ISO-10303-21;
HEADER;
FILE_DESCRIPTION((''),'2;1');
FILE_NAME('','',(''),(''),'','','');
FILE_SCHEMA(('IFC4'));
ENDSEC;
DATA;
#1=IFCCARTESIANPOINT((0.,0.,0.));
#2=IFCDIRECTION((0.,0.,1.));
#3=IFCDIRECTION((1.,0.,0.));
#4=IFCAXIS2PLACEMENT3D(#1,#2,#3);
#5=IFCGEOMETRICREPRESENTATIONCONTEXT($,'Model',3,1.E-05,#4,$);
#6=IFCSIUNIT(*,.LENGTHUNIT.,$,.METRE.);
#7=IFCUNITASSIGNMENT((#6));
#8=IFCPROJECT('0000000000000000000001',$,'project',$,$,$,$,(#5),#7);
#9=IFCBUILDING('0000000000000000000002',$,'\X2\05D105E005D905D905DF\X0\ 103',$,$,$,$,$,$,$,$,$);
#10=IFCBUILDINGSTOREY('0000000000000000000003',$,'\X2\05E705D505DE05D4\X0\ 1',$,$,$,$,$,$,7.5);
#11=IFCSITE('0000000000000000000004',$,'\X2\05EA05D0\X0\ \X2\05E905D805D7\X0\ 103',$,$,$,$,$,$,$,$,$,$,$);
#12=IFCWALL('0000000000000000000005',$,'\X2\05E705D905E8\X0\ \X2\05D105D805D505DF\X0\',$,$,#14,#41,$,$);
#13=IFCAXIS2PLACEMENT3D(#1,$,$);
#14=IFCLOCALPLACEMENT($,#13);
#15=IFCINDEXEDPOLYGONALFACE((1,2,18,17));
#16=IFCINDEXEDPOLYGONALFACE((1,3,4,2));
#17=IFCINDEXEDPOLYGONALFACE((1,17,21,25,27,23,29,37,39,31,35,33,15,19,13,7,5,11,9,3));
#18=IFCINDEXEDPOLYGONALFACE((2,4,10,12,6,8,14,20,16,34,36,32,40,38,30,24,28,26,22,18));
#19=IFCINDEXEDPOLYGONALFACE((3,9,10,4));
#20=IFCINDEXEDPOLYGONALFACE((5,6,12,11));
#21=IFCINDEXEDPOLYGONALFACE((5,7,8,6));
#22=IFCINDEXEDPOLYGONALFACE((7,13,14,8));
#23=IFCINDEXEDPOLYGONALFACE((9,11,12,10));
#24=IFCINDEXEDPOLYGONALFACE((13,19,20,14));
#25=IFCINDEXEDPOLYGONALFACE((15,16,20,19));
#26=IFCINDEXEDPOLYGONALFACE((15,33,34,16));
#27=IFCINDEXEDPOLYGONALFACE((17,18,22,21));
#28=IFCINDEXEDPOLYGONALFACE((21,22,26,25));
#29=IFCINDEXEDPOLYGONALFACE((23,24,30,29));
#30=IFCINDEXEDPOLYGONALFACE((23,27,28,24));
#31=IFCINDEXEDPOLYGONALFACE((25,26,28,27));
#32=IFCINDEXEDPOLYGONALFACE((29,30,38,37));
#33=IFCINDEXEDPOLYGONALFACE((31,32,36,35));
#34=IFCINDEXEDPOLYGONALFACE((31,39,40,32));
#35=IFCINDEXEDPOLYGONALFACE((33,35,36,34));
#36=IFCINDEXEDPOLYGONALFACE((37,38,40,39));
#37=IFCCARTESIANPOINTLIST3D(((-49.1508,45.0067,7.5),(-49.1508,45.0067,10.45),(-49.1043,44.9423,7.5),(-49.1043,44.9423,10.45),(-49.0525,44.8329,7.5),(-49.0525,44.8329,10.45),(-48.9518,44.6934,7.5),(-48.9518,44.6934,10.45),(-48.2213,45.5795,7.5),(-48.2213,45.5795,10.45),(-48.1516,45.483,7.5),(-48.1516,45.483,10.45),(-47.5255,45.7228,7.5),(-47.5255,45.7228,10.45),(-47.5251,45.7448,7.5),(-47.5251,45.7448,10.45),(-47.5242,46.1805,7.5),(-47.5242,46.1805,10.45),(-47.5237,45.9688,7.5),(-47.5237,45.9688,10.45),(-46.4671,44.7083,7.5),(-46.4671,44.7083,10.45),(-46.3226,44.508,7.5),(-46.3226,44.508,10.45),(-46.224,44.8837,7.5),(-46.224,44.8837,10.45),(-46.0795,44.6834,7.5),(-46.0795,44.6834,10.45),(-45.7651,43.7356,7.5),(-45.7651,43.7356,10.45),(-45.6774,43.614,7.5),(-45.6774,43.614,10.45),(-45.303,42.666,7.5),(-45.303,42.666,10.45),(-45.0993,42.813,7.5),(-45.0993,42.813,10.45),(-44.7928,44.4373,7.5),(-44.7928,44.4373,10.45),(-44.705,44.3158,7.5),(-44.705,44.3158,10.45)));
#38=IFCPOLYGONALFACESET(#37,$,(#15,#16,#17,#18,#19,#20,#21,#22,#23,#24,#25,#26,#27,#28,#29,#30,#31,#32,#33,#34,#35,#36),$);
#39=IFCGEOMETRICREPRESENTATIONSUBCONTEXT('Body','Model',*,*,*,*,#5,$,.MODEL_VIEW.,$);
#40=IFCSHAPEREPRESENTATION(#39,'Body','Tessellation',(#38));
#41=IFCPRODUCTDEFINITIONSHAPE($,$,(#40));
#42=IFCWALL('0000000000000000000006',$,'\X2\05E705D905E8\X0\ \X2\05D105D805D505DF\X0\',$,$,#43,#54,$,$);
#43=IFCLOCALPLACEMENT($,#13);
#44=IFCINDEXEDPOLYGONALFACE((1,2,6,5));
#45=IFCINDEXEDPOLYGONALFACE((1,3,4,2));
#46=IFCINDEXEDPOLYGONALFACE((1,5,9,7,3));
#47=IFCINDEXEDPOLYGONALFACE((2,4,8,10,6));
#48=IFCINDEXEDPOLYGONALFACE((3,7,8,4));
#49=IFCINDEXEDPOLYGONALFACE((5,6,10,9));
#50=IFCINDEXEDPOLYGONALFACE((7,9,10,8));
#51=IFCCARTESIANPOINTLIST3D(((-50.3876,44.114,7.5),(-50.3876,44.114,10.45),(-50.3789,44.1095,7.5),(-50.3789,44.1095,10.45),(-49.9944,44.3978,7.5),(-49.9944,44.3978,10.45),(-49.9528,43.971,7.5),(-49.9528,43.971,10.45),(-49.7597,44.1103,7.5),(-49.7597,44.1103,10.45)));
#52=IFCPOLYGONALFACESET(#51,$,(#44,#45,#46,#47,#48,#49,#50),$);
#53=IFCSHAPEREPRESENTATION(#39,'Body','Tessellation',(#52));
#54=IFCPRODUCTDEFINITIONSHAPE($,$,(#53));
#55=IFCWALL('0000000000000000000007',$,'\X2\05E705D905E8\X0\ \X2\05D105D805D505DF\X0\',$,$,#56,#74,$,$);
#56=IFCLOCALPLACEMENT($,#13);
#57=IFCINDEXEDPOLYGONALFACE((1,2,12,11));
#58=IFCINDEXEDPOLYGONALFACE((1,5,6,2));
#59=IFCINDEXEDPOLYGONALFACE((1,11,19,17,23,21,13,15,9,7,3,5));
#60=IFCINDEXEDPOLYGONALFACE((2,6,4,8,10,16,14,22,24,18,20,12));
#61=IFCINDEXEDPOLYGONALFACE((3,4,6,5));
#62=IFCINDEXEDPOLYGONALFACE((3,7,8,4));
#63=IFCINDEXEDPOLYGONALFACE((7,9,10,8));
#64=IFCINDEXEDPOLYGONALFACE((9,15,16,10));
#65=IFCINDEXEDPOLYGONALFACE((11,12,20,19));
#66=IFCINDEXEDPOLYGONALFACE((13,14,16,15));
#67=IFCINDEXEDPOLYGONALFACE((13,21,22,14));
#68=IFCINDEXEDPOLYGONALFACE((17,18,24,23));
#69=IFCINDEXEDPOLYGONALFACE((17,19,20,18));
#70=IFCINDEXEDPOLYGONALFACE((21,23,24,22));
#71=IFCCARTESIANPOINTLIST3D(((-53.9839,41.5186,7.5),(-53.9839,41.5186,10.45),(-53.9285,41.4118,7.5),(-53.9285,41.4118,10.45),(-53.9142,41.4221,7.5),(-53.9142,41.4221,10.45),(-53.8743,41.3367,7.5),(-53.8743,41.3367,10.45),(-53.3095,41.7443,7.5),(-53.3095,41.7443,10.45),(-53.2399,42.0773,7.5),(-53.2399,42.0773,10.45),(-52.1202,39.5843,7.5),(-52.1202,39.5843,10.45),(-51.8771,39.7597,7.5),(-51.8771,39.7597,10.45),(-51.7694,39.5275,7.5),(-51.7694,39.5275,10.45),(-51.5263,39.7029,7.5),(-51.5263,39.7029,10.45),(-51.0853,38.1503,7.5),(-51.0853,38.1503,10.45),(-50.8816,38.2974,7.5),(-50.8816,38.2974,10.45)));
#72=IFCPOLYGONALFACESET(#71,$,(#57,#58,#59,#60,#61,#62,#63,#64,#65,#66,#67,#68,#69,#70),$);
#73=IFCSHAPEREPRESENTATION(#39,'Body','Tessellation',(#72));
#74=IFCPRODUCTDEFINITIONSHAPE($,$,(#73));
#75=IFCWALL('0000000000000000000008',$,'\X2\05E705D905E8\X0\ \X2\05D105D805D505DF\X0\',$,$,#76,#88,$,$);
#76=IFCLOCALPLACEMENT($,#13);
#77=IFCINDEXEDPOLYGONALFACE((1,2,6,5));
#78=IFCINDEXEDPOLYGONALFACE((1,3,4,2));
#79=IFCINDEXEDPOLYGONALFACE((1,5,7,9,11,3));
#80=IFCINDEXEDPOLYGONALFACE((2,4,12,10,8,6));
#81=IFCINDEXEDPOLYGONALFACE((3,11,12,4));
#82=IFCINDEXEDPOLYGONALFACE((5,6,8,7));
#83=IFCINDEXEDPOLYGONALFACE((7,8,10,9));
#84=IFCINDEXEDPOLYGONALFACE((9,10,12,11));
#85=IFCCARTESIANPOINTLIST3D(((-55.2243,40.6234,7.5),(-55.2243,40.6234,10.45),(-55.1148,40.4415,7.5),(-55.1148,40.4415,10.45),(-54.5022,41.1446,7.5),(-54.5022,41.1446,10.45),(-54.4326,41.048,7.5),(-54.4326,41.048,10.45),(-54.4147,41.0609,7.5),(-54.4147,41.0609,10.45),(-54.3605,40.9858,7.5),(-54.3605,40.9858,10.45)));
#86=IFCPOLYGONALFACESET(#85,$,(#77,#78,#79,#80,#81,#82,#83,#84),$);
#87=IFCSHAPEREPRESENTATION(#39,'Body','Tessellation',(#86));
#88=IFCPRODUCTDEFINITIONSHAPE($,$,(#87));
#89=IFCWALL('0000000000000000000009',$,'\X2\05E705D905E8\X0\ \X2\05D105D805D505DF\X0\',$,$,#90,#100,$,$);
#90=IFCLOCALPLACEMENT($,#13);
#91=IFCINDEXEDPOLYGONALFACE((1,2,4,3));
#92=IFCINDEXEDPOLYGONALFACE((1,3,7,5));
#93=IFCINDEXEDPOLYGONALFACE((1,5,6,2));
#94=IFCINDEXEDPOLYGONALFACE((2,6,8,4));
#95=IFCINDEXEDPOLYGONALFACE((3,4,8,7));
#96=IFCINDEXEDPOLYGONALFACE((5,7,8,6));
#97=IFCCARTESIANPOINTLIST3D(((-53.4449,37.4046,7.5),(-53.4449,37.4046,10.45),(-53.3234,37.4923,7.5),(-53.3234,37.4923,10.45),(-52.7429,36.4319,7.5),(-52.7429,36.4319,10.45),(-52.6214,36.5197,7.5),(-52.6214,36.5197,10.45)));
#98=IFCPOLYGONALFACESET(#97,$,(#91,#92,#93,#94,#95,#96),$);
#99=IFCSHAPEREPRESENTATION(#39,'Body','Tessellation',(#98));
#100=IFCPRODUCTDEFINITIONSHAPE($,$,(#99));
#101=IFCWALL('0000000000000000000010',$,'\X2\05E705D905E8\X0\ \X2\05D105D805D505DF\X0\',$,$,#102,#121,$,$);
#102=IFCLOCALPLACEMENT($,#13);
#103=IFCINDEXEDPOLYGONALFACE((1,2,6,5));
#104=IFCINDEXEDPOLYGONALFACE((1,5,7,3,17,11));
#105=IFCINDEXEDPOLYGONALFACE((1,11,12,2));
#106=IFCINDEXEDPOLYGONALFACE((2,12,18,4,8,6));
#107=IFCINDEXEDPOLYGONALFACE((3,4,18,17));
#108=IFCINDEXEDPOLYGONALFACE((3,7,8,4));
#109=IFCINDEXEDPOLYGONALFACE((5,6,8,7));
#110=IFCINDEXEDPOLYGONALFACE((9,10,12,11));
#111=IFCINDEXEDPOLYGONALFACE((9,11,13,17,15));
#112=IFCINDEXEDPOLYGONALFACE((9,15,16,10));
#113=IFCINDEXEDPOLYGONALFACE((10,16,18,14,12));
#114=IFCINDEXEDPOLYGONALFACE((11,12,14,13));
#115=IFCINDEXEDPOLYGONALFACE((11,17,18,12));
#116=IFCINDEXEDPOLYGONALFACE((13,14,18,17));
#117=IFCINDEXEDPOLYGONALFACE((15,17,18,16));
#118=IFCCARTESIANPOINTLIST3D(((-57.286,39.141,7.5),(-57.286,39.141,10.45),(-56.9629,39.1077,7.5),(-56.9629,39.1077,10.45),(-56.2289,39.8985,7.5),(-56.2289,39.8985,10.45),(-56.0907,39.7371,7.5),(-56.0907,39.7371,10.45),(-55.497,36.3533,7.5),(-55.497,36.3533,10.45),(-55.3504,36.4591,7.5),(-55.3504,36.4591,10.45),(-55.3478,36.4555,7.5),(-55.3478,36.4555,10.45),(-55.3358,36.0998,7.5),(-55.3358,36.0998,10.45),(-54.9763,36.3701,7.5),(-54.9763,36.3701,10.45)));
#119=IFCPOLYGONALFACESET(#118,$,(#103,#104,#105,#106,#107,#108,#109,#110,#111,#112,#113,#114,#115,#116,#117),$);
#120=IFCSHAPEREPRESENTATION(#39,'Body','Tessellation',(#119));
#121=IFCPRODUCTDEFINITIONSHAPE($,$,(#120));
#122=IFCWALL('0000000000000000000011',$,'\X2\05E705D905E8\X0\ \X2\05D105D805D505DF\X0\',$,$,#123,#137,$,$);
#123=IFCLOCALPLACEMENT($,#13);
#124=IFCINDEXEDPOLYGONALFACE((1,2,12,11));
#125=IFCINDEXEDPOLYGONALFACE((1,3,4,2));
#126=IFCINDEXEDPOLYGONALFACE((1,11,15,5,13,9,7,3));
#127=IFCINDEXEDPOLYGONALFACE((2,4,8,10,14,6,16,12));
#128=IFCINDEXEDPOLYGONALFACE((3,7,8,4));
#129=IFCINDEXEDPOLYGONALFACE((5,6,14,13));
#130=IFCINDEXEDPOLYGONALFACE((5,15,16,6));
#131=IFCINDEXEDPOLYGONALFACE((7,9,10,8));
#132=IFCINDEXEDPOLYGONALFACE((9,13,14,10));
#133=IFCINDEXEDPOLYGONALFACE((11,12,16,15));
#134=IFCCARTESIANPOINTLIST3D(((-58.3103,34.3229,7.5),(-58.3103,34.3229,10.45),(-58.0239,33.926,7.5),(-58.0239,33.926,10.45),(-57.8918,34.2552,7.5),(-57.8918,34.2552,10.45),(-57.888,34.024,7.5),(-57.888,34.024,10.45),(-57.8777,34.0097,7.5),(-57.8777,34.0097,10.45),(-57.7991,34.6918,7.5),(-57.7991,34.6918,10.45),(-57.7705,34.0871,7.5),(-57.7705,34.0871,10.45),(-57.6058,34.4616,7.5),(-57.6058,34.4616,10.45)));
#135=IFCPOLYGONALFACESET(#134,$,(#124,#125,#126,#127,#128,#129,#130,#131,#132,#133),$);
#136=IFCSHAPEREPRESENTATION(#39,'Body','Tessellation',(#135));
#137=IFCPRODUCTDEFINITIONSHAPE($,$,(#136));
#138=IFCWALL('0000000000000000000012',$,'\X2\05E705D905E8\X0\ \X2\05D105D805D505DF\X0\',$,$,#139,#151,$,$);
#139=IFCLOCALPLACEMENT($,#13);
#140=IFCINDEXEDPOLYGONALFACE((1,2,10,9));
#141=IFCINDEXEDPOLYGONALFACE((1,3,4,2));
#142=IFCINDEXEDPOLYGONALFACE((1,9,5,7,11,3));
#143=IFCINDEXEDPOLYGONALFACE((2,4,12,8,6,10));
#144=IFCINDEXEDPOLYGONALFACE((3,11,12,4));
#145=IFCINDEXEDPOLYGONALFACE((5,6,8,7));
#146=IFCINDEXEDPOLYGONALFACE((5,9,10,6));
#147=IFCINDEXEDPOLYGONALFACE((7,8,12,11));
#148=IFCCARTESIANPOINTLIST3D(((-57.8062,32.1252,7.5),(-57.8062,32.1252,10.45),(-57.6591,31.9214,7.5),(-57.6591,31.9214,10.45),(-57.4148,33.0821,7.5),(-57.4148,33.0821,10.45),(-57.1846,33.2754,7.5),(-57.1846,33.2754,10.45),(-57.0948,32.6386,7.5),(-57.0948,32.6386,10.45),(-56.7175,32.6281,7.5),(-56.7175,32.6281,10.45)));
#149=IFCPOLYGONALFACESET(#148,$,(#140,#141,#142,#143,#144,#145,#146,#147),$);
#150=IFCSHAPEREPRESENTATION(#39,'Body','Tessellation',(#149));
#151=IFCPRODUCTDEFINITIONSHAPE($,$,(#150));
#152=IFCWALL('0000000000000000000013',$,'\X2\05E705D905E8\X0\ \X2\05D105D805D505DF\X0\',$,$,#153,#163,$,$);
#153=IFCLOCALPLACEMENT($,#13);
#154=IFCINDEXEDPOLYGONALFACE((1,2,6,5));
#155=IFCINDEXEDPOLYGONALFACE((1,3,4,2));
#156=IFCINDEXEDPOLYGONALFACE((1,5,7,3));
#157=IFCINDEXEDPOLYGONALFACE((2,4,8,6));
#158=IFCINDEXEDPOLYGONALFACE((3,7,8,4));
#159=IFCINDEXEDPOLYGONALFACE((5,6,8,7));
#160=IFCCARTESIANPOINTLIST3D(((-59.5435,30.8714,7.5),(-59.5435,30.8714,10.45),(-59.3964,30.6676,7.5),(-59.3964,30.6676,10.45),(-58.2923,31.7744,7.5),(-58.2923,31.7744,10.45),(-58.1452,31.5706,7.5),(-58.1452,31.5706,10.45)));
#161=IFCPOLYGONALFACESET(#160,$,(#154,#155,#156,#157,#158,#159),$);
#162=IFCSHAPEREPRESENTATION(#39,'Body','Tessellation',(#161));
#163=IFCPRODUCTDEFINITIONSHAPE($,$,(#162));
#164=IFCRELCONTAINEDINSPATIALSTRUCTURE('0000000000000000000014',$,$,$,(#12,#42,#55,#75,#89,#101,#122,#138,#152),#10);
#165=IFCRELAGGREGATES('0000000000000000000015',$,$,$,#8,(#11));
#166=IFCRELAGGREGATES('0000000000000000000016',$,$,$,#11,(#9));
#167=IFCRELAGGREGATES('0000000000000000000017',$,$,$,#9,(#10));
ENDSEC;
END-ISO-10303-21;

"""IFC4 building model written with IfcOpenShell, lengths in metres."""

from ifc_helpers import new_model, si_unit, frame, origin_with_axes, context, subcontext, project, spatial, polyline, outline, extrude, element, save


model = new_model("IFC4")

# Units and contexts
model_context = context("Model", 3, precision=1e-05, world=origin_with_axes())
body_context = subcontext(model_context, "Body", "Model", "MODEL_VIEW")
ifc_project = project(units=[si_unit("LENGTHUNIT", "METRE")], contexts=[model_context])

# Site, building, storey
site = spatial("IfcSite", under=ifc_project, Name="תא שטח 103")
building = spatial("IfcBuilding", under=site, Name="בניין 103")
storey = spatial("IfcBuildingStorey", under=building, Name="קומה 1", Elevation=7.5)

# Walls
element("IfcWall", 1, inside=storey, Name="קיר בטון", context=body_context, shape_type="SweptSolid", body=[
    extrude(outline(polyline([(-44.705, 44.3158), (-45.6774, 43.614), (-45.0993, 42.813), (-45.303, 42.666), (-47.5251, 45.7448), (-47.5237, 45.9688), (-47.5255, 45.7228), (-48.9518, 44.6934), (-49.0525, 44.8329), (-48.1516, 45.483), (-48.2213, 45.5795), (-49.1043, 44.9423), (-49.1508, 45.0067), (-47.5242, 46.1805), (-46.4671, 44.7083), (-46.224, 44.8837), (-46.0795, 44.6834), (-46.3226, 44.508), (-45.7651, 43.7356), (-44.7928, 44.4373), (-44.705, 44.3158)])), frame((0.0, 0.0, 7.5)), (0.0, 0.0, 1.0), 2.95),
])
element("IfcWall", 2, inside=storey, Name="קיר בטון", context=body_context, shape_type="SweptSolid", body=[
    extrude(outline(polyline([(-49.9944, 44.3978), (-49.7597, 44.1103), (-49.9528, 43.971), (-50.3789, 44.1095), (-50.3876, 44.114), (-49.9944, 44.3978)])), frame((0.0, 0.0, 7.5)), (0.0, 0.0, 1.0), 2.95),
])
element("IfcWall", 3, inside=storey, Name="קיר בטון", context=body_context, shape_type="SweptSolid", body=[
    extrude(outline(polyline([(-51.0853, 38.1503), (-52.1202, 39.5843), (-51.8771, 39.7597), (-53.3095, 41.7443), (-53.8743, 41.3367), (-53.9285, 41.4118), (-53.9142, 41.4221), (-53.9839, 41.5186), (-53.2399, 42.0773), (-51.5263, 39.7029), (-51.7694, 39.5275), (-50.8816, 38.2974), (-51.0853, 38.1503)])), frame((0.0, 0.0, 7.5)), (0.0, 0.0, 1.0), 2.95),
])
element("IfcWall", 4, inside=storey, Name="קיר בטון", context=body_context, shape_type="SweptSolid", body=[
    extrude(outline(polyline([(-55.1148, 40.4415), (-55.2243, 40.6234), (-54.5022, 41.1446), (-54.4326, 41.048), (-54.4147, 41.0609), (-54.3605, 40.9858), (-55.1148, 40.4415)])), frame((0.0, 0.0, 7.5)), (0.0, 0.0, 1.0), 2.95),
])
element("IfcWall", 5, inside=storey, Name="קיר בטון", context=body_context, shape_type="SweptSolid", body=[
    extrude(outline(polyline([(-52.7429, 36.4319), (-53.4449, 37.4046), (-53.3234, 37.4923), (-52.6214, 36.5197), (-52.7429, 36.4319)])), frame((0.0, 0.0, 7.5)), (0.0, 0.0, 1.0), 2.95),
])
element("IfcWall", 6, inside=storey, Name="קיר בטון", context=body_context, shape_type="SweptSolid", body=[
    extrude(outline(polyline([(-54.9763, 36.3701), (-55.3358, 36.0998), (-55.497, 36.3533), (-55.3504, 36.4591), (-57.286, 39.141), (-56.2289, 39.8985), (-56.0907, 39.7371), (-56.9629, 39.1077), (-54.9763, 36.3701)]), holes=[polyline([(-55.3478, 36.4555), (-55.3504, 36.4591), (-54.9763, 36.3701), (-55.3478, 36.4555)])]), frame((0.0, 0.0, 7.5)), (0.0, 0.0, 1.0), 2.95),
])
element("IfcWall", 7, inside=storey, Name="קיר בטון", context=body_context, shape_type="SweptSolid", body=[
    extrude(outline(polyline([(-57.888, 34.024), (-58.0239, 33.926), (-58.3103, 34.3229), (-57.7991, 34.6918), (-57.6058, 34.4616), (-57.8918, 34.2552), (-57.7705, 34.0871), (-57.8777, 34.0097), (-57.888, 34.024)])), frame((0.0, 0.0, 7.5)), (0.0, 0.0, 1.0), 2.95),
])
element("IfcWall", 8, inside=storey, Name="קיר בטון", context=body_context, shape_type="SweptSolid", body=[
    extrude(outline(polyline([(-57.6591, 31.9214), (-57.8062, 32.1252), (-57.0948, 32.6386), (-57.4148, 33.0821), (-57.1846, 33.2754), (-56.7175, 32.6281), (-57.6591, 31.9214)])), frame((0.0, 0.0, 7.5)), (0.0, 0.0, 1.0), 2.95),
])
element("IfcWall", 9, inside=storey, Name="קיר בטון", context=body_context, shape_type="SweptSolid", body=[
    extrude(outline(polyline([(-59.5435, 30.8714), (-58.2923, 31.7744), (-58.1452, 31.5706), (-59.3964, 30.6676), (-59.5435, 30.8714)])), frame((0.0, 0.0, 7.5)), (0.0, 0.0, 1.0), 2.95),
])

save(model, "model.ifc")
